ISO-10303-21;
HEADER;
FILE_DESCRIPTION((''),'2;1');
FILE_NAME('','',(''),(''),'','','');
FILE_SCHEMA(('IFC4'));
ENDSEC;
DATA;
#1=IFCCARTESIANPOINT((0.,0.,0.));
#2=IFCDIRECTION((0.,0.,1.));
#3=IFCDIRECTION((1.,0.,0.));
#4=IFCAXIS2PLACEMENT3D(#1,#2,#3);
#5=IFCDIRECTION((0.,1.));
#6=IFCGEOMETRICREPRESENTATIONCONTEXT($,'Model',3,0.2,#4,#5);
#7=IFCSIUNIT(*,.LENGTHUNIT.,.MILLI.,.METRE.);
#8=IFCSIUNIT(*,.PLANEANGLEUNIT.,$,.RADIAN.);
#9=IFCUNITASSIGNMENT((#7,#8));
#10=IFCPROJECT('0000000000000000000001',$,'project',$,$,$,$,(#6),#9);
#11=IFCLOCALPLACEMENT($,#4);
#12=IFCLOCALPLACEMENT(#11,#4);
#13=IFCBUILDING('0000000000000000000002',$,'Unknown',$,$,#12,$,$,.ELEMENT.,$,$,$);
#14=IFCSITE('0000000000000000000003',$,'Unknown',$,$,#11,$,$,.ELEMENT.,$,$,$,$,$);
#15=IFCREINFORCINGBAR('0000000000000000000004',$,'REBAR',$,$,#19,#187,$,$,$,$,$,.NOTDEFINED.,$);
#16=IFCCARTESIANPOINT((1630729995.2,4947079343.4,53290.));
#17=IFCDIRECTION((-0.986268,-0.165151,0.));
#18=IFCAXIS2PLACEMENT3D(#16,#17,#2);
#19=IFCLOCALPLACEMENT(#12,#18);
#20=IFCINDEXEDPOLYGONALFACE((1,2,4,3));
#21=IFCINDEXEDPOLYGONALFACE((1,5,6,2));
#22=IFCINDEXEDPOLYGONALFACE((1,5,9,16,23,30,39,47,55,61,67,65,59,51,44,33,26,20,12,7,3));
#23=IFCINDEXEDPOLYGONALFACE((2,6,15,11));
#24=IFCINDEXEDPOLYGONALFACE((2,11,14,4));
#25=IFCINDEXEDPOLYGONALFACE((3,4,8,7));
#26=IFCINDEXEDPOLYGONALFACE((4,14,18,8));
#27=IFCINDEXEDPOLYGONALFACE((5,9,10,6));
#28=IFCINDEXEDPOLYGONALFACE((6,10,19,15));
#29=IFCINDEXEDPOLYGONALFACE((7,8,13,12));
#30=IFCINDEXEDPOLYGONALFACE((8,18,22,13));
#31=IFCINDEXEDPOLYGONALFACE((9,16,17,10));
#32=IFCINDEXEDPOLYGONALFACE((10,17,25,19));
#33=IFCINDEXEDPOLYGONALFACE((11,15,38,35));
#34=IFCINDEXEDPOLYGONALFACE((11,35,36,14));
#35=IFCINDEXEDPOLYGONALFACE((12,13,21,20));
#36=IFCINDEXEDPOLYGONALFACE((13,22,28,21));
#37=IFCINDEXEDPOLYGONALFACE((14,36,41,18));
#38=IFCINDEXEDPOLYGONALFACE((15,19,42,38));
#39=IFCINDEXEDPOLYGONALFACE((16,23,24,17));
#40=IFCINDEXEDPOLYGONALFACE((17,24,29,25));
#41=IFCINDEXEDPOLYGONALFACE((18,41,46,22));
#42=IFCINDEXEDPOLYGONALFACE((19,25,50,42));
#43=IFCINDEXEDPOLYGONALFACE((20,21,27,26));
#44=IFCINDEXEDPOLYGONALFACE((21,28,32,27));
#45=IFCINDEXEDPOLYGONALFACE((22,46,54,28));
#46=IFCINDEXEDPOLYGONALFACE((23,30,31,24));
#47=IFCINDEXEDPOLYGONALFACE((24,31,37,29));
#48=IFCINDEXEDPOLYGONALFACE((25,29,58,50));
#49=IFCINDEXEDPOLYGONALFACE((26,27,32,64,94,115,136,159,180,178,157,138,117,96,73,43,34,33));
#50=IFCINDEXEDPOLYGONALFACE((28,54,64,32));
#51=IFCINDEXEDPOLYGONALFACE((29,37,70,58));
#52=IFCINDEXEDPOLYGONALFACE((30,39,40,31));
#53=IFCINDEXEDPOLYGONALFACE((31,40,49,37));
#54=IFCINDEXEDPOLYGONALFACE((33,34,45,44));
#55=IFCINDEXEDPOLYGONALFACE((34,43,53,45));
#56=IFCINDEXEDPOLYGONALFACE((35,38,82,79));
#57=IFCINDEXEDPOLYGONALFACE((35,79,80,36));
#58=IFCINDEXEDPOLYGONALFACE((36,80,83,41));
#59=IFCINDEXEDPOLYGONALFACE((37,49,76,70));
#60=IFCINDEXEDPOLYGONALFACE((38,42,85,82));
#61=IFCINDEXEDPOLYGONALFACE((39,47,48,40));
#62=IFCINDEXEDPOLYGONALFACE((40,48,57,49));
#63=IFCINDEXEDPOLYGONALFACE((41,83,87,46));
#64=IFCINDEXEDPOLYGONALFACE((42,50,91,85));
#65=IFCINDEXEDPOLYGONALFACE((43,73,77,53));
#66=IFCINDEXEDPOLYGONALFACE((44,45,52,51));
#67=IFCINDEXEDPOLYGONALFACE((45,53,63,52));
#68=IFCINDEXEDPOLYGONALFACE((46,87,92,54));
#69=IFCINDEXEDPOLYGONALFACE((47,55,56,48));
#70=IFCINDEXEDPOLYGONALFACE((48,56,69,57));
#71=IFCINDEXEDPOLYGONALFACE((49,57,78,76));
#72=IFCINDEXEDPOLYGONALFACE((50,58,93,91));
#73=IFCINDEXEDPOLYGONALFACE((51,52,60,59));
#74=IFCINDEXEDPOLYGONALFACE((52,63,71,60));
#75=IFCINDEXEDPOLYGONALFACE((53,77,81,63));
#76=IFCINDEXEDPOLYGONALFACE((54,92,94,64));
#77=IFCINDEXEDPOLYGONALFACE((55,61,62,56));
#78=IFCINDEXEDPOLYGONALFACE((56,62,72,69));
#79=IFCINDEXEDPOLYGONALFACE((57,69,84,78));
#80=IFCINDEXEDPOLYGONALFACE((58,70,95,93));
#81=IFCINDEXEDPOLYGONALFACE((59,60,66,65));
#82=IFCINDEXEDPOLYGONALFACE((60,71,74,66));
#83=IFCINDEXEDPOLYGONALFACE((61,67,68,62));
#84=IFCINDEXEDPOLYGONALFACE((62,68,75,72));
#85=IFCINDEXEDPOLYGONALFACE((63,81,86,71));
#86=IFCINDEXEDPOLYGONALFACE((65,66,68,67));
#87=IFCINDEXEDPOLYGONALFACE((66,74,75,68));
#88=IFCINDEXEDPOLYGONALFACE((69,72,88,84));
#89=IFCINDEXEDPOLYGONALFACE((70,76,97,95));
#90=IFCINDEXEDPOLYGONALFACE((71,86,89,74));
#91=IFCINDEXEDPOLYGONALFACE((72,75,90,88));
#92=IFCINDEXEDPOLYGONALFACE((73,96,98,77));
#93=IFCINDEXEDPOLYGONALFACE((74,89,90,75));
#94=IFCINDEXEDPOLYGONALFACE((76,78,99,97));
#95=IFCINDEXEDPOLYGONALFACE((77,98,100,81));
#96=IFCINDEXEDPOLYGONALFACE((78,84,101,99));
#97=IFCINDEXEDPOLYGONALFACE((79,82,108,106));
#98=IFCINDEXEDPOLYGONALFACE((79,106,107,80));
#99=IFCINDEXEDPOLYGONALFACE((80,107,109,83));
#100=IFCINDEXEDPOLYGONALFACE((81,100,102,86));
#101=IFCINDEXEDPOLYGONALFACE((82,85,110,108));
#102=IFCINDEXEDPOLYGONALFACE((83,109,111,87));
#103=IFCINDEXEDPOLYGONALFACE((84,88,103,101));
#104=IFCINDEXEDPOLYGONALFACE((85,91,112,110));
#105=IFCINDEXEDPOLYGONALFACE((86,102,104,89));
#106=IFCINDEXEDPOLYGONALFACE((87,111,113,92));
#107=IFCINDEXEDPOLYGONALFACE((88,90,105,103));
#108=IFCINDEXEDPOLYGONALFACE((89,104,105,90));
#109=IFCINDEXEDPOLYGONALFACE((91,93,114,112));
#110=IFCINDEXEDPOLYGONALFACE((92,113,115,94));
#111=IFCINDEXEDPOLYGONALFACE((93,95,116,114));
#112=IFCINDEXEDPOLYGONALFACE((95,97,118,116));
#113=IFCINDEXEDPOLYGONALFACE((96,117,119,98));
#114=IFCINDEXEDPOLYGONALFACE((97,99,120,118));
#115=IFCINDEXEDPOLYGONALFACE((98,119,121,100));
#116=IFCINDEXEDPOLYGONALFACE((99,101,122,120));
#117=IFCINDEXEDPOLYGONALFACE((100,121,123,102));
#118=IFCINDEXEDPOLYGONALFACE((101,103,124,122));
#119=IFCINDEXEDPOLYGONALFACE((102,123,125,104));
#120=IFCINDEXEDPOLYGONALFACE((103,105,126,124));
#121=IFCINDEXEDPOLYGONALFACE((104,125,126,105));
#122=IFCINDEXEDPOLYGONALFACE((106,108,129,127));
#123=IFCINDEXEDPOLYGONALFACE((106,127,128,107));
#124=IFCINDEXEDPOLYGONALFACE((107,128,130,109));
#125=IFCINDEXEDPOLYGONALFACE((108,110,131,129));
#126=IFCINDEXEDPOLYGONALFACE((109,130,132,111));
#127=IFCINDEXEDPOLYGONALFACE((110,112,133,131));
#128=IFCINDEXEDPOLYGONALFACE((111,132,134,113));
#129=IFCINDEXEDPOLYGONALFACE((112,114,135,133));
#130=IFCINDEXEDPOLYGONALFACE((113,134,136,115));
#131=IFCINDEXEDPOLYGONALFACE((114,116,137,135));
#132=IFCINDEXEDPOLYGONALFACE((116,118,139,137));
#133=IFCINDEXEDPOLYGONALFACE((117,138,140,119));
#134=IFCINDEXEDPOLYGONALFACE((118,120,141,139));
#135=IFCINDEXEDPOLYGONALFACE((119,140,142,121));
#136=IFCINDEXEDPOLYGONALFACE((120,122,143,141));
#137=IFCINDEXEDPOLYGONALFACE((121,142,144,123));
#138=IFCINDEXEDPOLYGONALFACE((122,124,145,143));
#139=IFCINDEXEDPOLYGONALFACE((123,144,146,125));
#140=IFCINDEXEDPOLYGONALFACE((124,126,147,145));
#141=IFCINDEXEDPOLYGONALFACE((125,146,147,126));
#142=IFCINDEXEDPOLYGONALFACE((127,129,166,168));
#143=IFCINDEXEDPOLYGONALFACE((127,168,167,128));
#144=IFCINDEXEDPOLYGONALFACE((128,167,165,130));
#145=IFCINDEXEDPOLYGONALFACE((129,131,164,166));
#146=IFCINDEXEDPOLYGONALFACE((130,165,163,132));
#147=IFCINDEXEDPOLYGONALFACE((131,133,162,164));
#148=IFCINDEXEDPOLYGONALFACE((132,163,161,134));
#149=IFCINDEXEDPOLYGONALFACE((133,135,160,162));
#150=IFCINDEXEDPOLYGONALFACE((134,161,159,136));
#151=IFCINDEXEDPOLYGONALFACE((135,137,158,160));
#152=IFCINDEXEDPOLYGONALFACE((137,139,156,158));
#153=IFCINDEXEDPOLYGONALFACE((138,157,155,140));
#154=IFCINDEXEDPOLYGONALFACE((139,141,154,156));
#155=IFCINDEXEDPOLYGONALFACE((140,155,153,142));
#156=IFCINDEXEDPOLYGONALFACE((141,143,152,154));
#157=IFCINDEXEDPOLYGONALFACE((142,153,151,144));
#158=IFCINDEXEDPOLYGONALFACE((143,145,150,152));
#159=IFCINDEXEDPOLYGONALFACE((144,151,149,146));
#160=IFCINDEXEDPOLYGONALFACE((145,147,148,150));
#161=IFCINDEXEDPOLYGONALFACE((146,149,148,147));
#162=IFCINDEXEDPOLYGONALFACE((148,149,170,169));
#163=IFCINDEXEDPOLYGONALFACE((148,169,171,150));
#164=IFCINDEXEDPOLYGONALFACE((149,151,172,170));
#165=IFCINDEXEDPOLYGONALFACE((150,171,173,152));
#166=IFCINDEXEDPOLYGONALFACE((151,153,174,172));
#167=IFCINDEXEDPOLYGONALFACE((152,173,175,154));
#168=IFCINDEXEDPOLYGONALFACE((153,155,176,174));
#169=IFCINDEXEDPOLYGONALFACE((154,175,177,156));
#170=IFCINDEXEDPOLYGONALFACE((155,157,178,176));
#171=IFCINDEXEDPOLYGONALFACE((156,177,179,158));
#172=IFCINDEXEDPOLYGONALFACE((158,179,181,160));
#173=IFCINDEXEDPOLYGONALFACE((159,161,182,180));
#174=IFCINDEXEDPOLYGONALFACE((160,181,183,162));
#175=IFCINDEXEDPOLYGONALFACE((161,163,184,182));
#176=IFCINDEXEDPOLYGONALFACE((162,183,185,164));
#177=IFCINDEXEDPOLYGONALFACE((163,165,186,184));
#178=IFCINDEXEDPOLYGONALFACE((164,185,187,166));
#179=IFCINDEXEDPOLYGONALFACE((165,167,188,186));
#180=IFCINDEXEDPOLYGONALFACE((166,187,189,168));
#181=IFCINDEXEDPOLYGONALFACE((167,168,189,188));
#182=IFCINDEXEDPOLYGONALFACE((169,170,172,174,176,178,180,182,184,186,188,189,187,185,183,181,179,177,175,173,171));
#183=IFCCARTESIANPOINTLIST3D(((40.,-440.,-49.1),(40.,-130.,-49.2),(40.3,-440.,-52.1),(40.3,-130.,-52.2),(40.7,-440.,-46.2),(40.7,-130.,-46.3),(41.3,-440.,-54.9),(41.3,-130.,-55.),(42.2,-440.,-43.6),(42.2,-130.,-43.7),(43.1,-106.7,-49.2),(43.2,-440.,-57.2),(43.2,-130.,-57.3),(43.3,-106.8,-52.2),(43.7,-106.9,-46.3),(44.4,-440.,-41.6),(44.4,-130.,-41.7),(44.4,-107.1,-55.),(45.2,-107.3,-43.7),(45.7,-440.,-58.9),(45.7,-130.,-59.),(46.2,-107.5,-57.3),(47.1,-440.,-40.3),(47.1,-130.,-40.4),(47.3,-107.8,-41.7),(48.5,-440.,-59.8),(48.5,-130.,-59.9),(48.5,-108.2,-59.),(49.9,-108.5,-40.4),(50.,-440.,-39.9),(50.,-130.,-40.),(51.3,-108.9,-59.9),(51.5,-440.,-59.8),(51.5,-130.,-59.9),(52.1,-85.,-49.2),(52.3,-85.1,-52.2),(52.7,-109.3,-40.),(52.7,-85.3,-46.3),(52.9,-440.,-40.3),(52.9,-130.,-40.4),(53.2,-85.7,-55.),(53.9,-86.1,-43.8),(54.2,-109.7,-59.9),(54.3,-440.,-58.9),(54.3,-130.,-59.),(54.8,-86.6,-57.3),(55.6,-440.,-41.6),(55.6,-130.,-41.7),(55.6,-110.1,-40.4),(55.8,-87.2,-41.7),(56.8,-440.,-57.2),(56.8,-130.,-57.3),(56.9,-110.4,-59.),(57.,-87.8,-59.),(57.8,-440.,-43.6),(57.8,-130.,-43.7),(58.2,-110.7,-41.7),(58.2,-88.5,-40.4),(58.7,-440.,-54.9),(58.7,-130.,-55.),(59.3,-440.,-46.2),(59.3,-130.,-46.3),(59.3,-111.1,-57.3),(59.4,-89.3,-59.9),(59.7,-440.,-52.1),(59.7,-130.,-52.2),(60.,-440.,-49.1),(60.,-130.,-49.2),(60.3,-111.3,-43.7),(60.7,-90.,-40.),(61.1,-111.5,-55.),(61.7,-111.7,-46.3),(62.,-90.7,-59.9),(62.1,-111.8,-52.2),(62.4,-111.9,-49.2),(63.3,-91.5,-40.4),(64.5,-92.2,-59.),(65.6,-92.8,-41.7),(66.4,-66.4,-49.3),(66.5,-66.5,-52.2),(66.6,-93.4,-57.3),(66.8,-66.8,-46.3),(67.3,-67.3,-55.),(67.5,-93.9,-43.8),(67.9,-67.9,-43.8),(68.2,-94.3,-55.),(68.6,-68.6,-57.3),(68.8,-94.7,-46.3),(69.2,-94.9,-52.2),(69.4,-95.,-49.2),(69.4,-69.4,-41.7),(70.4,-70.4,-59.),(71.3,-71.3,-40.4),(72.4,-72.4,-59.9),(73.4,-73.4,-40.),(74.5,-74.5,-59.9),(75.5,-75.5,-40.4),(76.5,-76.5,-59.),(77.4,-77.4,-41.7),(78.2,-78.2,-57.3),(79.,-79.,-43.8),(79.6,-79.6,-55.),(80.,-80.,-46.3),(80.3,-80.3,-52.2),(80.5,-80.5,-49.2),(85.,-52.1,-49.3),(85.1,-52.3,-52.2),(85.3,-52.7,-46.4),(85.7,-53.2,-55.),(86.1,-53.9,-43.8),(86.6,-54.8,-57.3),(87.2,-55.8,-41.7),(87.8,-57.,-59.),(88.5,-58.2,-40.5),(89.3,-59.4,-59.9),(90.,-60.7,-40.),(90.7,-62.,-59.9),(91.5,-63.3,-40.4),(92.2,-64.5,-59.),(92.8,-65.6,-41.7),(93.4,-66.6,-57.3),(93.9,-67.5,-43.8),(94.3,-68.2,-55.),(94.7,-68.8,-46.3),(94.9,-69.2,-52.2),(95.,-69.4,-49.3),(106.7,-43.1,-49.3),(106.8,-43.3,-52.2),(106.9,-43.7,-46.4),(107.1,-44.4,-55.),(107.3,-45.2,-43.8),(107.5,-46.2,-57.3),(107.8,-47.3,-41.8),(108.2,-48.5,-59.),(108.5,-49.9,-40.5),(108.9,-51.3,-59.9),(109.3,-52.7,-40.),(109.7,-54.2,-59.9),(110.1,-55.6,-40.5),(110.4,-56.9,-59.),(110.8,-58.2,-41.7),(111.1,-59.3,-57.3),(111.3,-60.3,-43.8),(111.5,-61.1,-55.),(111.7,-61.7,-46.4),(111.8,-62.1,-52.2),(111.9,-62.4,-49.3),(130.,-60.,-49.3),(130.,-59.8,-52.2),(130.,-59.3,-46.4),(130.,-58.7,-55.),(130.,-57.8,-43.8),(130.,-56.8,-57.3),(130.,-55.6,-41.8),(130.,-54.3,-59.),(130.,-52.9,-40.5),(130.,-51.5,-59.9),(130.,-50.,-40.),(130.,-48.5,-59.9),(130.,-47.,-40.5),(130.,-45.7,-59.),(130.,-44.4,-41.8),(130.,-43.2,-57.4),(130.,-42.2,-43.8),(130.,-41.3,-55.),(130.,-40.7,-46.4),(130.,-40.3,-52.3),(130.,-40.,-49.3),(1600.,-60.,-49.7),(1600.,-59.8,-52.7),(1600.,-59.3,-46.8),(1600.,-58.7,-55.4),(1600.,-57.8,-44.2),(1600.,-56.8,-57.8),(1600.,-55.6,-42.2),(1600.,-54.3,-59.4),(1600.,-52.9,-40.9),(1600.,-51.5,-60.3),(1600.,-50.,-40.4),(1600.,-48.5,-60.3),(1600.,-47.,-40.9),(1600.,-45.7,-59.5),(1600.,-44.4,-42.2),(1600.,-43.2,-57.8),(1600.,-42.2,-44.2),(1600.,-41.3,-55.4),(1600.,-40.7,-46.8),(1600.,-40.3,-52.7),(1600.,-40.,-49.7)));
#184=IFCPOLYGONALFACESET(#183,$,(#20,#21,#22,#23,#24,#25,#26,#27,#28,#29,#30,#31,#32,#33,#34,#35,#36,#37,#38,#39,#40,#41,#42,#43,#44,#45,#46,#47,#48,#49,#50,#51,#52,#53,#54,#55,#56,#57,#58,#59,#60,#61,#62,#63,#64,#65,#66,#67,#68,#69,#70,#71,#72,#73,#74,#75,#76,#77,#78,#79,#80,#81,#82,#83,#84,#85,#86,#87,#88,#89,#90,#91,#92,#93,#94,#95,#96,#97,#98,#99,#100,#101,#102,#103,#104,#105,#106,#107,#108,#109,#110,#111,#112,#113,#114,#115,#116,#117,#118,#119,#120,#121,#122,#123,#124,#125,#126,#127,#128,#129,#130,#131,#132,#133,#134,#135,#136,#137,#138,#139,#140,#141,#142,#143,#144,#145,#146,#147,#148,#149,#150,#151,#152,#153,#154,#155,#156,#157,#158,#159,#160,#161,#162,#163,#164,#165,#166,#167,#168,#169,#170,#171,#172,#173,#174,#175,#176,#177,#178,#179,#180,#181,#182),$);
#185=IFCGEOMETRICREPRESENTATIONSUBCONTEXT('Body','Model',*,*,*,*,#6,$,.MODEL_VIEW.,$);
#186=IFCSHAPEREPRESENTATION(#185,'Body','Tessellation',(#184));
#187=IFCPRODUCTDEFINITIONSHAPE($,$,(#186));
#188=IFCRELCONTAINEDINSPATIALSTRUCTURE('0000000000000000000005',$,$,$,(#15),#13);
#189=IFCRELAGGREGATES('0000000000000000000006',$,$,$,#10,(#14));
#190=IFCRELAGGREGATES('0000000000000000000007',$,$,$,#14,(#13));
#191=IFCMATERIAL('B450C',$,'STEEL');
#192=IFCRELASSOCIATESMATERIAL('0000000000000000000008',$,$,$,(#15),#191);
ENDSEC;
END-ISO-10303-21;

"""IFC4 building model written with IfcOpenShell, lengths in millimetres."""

from ifc_helpers import new_model, entity, si_unit, direction, frame, origin_with_axes, place, context, subcontext, project, spatial, material, element, save


model = new_model("IFC4")

# Units and contexts
model_context = context("Model", 3, precision=0.2, world=origin_with_axes(), true_north=direction((0.0, 1.0)))
body_context = subcontext(model_context, "Body", "Model", "MODEL_VIEW")
ifc_project = project(units=[si_unit("LENGTHUNIT", "METRE", prefix="MILLI"), si_unit("PLANEANGLEUNIT", "RADIAN")], contexts=[model_context])

# Site, building
site_placement = place(None, origin_with_axes())
site = spatial("IfcSite", under=ifc_project, at=site_placement, Name="Unknown", CompositionType="ELEMENT")
building_placement = place(site_placement, origin_with_axes())
building = spatial("IfcBuilding", under=site, at=building_placement, Name="Unknown", CompositionType="ELEMENT")

# Reinforcing bar
ifc_material = material(Name="B450C", Category="STEEL")
reinforcing_bar_1_placement = place(building_placement, frame((1630729995.2, 4947079343.4, 53290.0), z_axis=(-0.986268, -0.165151, 0.0), x_axis=(0.0, 0.0, 1.0)))
element("IfcReinforcingBar", 1, at=reinforcing_bar_1_placement, inside=building, material=ifc_material, Name="REBAR", PredefinedType="NOTDEFINED", context=body_context, shape_type="AdvancedSweptSolid", body=[
    entity("IfcSweptDiskSolid", entity("IfcIndexedPolyCurve", entity("IfcCartesianPointList3D", [[50.0, -440.0, -49.9], [50.0, -130.0, -50.0], [73.4, -73.4, -50.0], [130.0, -50.0, -50.0], [1600.0, -50.0, -50.4]]), [entity("IfcLineIndex", [1, 2]), entity("IfcArcIndex", [2, 3, 4]), entity("IfcLineIndex", [4, 5])]), 10.0),
])

save(model, "model.ifc")
